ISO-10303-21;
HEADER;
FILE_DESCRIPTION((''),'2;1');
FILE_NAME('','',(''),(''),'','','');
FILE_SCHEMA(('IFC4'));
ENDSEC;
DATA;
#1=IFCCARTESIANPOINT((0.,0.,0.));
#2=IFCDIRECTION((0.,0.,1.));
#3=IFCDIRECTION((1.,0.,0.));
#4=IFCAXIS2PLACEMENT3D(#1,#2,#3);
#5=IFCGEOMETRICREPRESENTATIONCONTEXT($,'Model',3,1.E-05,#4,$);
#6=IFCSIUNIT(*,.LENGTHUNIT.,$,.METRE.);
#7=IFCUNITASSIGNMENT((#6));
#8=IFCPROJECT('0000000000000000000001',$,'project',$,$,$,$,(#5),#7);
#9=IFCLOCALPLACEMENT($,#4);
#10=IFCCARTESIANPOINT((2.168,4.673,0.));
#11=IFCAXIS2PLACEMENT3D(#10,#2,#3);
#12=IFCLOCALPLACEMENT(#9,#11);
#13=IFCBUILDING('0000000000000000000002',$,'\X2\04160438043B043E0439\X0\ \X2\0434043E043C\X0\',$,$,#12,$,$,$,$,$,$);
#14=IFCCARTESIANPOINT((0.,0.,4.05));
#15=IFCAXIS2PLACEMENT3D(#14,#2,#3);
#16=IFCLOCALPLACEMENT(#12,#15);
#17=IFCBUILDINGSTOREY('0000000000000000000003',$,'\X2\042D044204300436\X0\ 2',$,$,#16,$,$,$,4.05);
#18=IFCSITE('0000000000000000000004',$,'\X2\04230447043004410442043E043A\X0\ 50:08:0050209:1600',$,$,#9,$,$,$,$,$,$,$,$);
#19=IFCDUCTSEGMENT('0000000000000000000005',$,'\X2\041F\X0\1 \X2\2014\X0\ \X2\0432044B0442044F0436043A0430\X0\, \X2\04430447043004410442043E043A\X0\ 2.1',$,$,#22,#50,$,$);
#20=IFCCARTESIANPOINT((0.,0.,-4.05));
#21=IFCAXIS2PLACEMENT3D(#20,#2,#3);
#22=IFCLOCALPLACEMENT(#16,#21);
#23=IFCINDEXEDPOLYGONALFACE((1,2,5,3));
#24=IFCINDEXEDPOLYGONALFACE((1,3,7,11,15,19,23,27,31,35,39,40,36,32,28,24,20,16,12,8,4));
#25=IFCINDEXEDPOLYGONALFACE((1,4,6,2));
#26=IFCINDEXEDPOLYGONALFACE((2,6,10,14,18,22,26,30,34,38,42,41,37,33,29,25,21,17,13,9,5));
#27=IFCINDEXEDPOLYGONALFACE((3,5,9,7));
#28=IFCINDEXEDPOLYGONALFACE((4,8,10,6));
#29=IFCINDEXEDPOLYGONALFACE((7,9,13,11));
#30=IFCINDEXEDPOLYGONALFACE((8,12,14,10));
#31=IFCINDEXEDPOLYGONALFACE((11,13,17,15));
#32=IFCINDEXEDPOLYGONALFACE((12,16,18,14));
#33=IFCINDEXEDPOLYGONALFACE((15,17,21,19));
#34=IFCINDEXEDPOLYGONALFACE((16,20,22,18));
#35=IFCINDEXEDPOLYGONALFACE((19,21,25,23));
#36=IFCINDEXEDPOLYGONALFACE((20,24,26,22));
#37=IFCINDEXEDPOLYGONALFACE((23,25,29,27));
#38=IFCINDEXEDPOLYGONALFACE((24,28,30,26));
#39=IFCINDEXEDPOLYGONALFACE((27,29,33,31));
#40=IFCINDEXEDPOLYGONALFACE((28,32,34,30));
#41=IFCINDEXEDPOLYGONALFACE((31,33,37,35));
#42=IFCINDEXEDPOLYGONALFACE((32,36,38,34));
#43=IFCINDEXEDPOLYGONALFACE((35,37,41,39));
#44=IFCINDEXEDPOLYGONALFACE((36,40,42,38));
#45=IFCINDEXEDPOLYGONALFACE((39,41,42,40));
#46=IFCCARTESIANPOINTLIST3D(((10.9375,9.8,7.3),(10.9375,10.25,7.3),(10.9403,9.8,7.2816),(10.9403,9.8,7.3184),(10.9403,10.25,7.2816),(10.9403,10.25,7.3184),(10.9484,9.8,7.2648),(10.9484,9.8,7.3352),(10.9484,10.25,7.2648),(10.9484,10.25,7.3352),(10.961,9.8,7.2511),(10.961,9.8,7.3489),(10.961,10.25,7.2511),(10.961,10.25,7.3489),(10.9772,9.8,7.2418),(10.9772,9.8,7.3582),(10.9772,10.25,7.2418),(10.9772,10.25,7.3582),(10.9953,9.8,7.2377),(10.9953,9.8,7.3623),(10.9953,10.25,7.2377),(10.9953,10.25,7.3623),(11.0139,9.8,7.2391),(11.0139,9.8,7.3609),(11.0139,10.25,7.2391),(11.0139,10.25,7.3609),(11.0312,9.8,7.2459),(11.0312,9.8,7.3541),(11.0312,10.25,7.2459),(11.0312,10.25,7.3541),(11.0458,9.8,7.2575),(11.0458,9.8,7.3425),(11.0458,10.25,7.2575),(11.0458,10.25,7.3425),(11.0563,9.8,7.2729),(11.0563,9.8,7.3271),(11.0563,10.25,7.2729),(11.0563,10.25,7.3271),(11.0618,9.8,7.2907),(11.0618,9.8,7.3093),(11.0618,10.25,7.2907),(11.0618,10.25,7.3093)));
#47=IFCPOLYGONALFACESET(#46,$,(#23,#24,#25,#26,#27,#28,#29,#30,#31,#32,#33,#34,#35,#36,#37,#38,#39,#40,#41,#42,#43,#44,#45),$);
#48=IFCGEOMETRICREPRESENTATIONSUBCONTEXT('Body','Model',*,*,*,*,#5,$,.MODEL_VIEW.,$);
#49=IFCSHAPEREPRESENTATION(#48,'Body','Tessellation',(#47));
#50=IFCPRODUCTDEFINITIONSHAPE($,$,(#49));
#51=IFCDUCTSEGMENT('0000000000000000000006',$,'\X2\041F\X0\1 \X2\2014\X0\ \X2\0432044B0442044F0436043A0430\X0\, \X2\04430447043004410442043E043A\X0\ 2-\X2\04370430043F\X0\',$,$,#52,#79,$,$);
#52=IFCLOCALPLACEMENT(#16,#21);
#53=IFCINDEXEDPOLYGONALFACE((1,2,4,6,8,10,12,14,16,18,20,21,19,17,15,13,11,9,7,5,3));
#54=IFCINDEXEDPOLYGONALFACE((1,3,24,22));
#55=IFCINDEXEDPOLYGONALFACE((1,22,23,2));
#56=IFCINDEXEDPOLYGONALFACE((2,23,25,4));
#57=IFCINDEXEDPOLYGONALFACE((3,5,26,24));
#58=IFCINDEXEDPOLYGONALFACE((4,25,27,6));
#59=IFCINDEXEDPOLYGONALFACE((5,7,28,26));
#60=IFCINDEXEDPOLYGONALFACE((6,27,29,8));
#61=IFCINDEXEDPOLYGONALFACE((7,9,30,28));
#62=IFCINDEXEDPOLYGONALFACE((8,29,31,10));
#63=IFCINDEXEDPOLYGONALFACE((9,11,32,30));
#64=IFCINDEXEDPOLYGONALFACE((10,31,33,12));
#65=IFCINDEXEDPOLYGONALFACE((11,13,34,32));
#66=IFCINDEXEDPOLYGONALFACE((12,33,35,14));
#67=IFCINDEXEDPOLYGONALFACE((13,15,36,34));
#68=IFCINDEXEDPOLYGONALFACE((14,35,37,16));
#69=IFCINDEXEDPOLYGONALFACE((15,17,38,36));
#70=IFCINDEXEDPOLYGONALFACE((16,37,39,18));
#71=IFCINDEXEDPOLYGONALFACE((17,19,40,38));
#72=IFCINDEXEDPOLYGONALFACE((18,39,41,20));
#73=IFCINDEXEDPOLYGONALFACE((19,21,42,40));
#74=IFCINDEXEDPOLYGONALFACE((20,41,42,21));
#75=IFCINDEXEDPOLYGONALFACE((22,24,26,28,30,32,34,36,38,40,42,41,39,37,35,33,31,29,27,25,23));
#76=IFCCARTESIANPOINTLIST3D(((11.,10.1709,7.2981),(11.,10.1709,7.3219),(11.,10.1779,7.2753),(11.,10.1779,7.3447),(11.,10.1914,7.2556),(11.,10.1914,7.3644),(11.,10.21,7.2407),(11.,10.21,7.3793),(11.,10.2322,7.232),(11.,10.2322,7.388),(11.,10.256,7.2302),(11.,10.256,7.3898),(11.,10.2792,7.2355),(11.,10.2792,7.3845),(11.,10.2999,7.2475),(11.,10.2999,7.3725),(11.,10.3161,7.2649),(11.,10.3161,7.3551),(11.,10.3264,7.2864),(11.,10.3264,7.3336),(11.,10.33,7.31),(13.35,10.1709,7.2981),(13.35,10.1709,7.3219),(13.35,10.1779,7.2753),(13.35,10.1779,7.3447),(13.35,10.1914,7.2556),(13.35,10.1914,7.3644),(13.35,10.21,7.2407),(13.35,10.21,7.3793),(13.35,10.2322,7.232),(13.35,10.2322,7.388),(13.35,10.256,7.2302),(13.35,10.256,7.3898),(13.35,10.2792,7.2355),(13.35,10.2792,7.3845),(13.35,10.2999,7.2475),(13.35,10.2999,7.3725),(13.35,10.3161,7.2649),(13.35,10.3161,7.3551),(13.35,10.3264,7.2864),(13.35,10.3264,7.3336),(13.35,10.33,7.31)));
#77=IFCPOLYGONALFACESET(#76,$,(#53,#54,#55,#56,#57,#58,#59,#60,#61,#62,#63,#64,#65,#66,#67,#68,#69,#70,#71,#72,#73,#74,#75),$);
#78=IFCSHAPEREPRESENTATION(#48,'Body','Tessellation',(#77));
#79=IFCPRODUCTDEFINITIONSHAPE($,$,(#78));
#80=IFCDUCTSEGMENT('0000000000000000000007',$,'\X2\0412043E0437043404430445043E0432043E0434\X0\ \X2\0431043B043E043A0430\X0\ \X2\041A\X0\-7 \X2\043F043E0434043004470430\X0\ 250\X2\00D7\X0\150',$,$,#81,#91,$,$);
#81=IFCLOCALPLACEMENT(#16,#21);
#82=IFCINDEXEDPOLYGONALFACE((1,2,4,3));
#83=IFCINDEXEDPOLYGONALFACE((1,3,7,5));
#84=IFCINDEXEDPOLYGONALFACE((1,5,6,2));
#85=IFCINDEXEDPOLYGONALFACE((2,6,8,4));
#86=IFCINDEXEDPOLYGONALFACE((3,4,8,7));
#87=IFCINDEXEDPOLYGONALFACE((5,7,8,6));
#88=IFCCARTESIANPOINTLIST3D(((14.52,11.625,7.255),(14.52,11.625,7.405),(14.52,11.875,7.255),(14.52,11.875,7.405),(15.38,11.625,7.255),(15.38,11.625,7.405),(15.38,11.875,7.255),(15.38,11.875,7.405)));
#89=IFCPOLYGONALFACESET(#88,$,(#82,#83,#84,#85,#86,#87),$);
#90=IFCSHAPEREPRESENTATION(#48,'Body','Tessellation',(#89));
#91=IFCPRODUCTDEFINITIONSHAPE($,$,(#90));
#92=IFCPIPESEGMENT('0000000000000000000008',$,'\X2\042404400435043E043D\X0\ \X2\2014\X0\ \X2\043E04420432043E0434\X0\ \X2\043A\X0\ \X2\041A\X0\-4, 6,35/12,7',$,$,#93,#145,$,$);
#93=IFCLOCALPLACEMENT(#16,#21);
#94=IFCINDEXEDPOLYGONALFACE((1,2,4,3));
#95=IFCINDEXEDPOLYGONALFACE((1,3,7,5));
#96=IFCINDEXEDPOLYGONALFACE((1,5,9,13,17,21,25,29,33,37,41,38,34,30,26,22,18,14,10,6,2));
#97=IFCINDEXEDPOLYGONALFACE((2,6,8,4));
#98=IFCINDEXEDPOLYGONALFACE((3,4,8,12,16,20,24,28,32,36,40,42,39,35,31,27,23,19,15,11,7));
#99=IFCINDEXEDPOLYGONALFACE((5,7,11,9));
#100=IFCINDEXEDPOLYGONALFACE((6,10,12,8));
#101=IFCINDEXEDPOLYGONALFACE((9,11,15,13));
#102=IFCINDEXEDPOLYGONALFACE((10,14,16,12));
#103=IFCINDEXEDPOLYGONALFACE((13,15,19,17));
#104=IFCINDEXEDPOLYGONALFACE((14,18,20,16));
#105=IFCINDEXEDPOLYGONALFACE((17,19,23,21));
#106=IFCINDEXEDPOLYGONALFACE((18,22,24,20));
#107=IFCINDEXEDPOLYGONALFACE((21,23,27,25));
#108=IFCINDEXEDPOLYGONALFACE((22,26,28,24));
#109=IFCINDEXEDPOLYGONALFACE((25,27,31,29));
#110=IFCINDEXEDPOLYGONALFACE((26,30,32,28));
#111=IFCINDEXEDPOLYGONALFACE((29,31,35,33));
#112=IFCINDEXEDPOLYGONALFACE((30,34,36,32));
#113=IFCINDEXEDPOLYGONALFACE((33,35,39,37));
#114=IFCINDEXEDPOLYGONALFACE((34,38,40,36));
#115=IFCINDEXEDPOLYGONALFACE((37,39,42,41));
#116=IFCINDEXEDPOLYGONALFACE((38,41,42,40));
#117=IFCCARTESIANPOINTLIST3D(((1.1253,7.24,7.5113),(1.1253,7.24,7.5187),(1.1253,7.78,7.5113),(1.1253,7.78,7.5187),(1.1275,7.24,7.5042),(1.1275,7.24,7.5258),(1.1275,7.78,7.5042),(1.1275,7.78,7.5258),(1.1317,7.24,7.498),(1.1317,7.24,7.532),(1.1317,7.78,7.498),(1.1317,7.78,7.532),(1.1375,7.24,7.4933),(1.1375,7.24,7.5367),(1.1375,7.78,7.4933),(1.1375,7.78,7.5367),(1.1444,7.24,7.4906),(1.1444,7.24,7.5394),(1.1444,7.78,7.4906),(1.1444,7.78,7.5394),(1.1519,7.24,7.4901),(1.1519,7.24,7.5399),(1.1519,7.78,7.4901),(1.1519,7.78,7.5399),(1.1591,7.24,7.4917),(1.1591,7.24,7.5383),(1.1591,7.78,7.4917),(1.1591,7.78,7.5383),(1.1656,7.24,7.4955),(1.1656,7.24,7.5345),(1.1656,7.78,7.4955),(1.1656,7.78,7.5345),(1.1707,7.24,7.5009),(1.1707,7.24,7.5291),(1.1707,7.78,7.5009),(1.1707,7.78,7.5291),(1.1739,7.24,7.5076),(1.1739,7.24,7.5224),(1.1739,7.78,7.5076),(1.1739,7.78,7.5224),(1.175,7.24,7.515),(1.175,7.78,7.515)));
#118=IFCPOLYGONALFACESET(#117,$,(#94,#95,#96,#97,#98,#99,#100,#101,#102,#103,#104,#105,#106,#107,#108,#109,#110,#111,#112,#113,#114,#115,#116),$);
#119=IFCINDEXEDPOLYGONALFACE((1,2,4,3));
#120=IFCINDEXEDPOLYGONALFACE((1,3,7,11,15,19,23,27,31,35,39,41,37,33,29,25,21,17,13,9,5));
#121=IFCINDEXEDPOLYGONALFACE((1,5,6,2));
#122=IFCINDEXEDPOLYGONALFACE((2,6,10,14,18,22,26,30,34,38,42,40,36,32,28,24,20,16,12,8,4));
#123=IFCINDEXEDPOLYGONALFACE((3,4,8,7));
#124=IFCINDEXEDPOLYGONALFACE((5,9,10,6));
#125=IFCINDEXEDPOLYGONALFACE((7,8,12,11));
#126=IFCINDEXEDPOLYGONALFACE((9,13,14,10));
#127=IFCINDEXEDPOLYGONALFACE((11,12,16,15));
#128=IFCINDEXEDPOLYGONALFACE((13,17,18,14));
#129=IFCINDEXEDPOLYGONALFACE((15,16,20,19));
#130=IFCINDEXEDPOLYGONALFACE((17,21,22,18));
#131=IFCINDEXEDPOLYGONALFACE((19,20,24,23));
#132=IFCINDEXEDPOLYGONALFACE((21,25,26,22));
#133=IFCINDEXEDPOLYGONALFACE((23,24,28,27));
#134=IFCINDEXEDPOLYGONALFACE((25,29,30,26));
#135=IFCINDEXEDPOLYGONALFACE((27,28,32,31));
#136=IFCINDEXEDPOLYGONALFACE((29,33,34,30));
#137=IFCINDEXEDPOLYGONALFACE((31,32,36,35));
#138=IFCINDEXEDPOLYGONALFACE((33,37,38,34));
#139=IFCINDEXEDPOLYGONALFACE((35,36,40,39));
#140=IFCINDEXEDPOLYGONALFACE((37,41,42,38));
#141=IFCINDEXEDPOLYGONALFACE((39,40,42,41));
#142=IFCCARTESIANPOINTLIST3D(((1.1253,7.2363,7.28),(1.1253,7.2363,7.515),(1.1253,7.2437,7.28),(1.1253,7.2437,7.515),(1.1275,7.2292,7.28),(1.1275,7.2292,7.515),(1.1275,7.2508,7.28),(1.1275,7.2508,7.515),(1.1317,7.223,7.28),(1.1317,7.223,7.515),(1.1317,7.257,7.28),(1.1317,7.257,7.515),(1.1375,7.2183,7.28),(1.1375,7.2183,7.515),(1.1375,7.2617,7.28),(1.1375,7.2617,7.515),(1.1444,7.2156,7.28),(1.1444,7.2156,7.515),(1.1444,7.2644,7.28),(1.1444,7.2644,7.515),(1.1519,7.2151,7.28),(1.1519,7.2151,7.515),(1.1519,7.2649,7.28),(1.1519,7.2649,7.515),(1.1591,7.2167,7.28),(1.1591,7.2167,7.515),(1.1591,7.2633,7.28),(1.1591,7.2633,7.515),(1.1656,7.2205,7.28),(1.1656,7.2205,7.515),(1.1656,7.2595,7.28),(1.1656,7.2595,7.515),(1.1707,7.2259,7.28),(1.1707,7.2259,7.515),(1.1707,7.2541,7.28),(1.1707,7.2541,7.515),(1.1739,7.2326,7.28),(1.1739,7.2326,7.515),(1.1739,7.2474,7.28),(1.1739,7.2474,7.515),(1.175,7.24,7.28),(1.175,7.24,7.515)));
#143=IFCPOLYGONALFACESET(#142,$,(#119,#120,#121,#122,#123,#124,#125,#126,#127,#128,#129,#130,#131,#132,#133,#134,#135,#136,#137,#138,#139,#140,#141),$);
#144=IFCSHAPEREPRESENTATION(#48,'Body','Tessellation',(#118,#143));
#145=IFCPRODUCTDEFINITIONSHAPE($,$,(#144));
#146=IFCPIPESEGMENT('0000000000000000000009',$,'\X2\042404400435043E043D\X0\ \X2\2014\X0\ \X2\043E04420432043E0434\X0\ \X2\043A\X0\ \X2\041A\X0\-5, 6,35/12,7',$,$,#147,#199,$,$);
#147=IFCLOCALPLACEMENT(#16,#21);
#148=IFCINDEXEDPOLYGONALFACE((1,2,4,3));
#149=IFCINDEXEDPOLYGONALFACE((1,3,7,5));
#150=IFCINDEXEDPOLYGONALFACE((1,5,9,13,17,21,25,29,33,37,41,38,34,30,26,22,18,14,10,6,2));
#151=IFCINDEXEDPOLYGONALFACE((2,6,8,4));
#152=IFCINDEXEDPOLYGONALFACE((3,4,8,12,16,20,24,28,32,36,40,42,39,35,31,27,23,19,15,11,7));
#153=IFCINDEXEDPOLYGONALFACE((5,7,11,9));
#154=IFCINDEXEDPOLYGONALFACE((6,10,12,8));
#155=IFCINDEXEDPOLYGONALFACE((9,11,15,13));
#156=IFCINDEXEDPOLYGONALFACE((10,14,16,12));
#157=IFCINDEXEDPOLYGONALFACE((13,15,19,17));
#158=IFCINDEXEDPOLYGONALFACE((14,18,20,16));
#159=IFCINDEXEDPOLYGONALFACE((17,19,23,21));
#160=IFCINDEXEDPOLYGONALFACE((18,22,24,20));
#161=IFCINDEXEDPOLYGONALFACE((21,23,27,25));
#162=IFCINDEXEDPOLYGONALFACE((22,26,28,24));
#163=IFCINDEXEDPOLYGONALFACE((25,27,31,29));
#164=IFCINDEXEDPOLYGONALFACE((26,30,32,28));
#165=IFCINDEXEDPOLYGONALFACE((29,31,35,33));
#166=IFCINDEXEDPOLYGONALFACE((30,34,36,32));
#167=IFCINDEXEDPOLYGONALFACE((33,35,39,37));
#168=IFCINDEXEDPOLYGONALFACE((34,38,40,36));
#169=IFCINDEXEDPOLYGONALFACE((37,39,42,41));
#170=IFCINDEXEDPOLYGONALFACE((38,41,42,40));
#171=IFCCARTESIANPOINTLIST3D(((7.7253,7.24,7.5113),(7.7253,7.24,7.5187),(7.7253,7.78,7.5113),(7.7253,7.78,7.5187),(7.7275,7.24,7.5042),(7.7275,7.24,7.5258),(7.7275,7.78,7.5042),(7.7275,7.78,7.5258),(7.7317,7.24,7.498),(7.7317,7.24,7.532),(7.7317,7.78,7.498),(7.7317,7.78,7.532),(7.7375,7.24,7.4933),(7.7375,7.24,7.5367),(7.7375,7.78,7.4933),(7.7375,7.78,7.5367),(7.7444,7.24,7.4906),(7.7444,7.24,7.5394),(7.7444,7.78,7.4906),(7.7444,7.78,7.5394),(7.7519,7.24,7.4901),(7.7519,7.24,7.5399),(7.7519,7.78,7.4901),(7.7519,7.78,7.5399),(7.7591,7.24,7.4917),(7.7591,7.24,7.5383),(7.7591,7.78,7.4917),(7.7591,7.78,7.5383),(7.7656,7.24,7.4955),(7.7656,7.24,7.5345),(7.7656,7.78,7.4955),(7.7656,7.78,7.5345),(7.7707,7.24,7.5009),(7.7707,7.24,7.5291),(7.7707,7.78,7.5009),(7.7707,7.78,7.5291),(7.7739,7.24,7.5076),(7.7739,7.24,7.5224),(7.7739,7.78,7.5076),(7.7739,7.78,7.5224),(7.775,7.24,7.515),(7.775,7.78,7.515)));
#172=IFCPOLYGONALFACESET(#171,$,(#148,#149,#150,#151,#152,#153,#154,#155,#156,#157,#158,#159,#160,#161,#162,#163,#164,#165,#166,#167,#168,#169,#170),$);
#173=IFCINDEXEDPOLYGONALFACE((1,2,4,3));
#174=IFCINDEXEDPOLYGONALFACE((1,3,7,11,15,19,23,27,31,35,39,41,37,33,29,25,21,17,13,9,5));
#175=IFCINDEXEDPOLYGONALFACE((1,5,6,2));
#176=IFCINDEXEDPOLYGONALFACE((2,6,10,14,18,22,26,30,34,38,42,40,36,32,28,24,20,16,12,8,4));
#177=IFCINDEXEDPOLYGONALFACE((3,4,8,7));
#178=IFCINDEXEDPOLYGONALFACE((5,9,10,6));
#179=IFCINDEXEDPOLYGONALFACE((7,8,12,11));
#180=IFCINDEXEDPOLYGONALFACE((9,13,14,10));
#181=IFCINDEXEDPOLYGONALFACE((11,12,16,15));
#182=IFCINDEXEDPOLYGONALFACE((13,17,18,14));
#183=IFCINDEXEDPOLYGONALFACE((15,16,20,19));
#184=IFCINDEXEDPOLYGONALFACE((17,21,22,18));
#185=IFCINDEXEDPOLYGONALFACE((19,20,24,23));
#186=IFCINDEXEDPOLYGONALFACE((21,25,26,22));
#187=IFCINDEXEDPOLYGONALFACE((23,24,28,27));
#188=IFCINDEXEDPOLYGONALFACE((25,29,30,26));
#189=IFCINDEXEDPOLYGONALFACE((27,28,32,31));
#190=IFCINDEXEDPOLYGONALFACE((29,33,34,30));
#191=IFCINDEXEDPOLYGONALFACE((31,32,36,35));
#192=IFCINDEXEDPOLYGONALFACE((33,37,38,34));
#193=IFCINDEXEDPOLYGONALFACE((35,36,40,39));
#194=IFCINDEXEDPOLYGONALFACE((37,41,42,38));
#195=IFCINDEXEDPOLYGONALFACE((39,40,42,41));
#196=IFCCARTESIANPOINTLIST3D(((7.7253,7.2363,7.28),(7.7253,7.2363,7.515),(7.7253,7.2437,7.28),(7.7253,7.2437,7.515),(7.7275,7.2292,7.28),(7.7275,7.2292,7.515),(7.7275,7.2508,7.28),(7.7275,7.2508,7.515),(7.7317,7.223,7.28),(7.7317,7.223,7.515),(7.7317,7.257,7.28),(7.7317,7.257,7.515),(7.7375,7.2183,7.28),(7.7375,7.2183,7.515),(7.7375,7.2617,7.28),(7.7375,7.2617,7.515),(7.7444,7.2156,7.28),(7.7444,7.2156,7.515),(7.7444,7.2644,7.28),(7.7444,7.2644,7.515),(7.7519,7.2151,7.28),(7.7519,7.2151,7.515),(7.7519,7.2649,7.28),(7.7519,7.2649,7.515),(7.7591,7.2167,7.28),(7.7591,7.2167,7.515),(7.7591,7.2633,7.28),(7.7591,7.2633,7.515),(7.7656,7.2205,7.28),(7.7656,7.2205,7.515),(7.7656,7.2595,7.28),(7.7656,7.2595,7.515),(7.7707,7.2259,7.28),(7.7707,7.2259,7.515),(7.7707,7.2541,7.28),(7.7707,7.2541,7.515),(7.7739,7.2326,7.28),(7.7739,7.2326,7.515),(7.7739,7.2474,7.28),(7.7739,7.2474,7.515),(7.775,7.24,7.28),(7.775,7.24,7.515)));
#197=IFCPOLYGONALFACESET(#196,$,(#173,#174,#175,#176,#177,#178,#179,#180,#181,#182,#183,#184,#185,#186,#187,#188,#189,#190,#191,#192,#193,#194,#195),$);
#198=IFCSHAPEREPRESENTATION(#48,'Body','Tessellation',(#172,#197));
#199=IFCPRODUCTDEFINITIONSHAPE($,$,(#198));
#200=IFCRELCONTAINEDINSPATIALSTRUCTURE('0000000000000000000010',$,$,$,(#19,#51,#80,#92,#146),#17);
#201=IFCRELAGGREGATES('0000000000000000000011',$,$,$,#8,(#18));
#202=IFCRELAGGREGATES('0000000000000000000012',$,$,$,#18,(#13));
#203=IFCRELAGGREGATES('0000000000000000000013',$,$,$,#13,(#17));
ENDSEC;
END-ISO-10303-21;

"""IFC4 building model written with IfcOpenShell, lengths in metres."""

from ifc_helpers import new_model, si_unit, frame, origin_with_axes, origin_2d, place, context, subcontext, project, spatial, rectangle, circle, extrude, element, save


model = new_model("IFC4")

# Units and contexts
model_context = context("Model", 3, precision=1e-05, world=origin_with_axes())
body_context = subcontext(model_context, "Body", "Model", "MODEL_VIEW")
ifc_project = project(units=[si_unit("LENGTHUNIT", "METRE")], contexts=[model_context])

# Site, building, storey
site_placement = place(None, origin_with_axes())
site = spatial("IfcSite", under=ifc_project, at=site_placement, Name="Участок 50:08:0050209:1600")
building_placement = place(site_placement, frame((2.168, 4.673, 0.0), z_axis=(0.0, 0.0, 1.0), x_axis=(1.0, 0.0, 0.0)))
building = spatial("IfcBuilding", under=site, at=building_placement, Name="Жилой дом")
storey_placement = place(building_placement, frame((0.0, 0.0, 4.05), z_axis=(0.0, 0.0, 1.0), x_axis=(1.0, 0.0, 0.0)))
storey = spatial("IfcBuildingStorey", under=building, at=storey_placement, Name="Этаж 2", Elevation=4.05)

# Duct segments
duct_segment_1_placement = place(storey_placement, frame((0.0, 0.0, -4.05), z_axis=(0.0, 0.0, 1.0), x_axis=(1.0, 0.0, 0.0)))
element("IfcDuctSegment", 1, at=duct_segment_1_placement, inside=storey, Name="П1 — вытяжка, участок 2.1", context=body_context, shape_type="SweptSolid", body=[
    extrude(circle(Radius=0.0625, at=origin_2d()), frame((11.0, 9.8, 7.3), z_axis=(0.0, 1.0, 0.0), x_axis=(-1.0, 0.0, 0.0)), (0.0, 0.0, 1.0), 0.45),
])
duct_segment_2_placement = place(storey_placement, frame((0.0, 0.0, -4.05), z_axis=(0.0, 0.0, 1.0), x_axis=(1.0, 0.0, 0.0)))
element("IfcDuctSegment", 2, at=duct_segment_2_placement, inside=storey, Name="П1 — вытяжка, участок 2-зап", context=body_context, shape_type="SweptSolid", body=[
    extrude(circle(Radius=0.08, at=origin_2d()), frame((11.0, 10.25, 7.31), z_axis=(1.0, 0.0, 0.0), x_axis=(0.0, 1.0, 0.0)), (0.0, 0.0, 1.0), 2.35),
])
duct_segment_3_placement = place(storey_placement, frame((0.0, 0.0, -4.05), z_axis=(0.0, 0.0, 1.0), x_axis=(1.0, 0.0, 0.0)))
element("IfcDuctSegment", 3, at=duct_segment_3_placement, inside=storey, Name="Воздуховод блока К-7 подача 250×150", context=body_context, shape_type="SweptSolid", body=[
    extrude(rectangle(XDim=0.25, YDim=0.15, at=origin_2d()), frame((14.52, 11.75, 7.33), z_axis=(1.0, 0.0, 0.0), x_axis=(0.0, 1.0, 0.0)), (0.0, 0.0, 1.0), 0.86),
])

# Pipe segments
pipe_segment_1_placement = place(storey_placement, frame((0.0, 0.0, -4.05), z_axis=(0.0, 0.0, 1.0), x_axis=(1.0, 0.0, 0.0)))
element("IfcPipeSegment", 4, at=pipe_segment_1_placement, inside=storey, Name="Фреон — отвод к К-4, 6,35/12,7", context=body_context, shape_type="SweptSolid", body=[
    extrude(circle(Radius=0.025, at=origin_2d()), frame((1.15, 7.78, 7.515), z_axis=(0.0, -1.0, 0.0), x_axis=(1.0, 0.0, 0.0)), (0.0, 0.0, 1.0), 0.54),
    extrude(circle(Radius=0.025, at=origin_2d()), frame((1.15, 7.24, 7.515), z_axis=(0.0, 0.0, -1.0), x_axis=(1.0, 0.0, 0.0)), (0.0, 0.0, 1.0), 0.235),
])
pipe_segment_2_placement = place(storey_placement, frame((0.0, 0.0, -4.05), z_axis=(0.0, 0.0, 1.0), x_axis=(1.0, 0.0, 0.0)))
element("IfcPipeSegment", 5, at=pipe_segment_2_placement, inside=storey, Name="Фреон — отвод к К-5, 6,35/12,7", context=body_context, shape_type="SweptSolid", body=[
    extrude(circle(Radius=0.025, at=origin_2d()), frame((7.75, 7.78, 7.515), z_axis=(0.0, -1.0, 0.0), x_axis=(1.0, 0.0, 0.0)), (0.0, 0.0, 1.0), 0.54),
    extrude(circle(Radius=0.025, at=origin_2d()), frame((7.75, 7.24, 7.515), z_axis=(0.0, 0.0, -1.0), x_axis=(1.0, 0.0, 0.0)), (0.0, 0.0, 1.0), 0.235),
])

save(model, "model.ifc")
